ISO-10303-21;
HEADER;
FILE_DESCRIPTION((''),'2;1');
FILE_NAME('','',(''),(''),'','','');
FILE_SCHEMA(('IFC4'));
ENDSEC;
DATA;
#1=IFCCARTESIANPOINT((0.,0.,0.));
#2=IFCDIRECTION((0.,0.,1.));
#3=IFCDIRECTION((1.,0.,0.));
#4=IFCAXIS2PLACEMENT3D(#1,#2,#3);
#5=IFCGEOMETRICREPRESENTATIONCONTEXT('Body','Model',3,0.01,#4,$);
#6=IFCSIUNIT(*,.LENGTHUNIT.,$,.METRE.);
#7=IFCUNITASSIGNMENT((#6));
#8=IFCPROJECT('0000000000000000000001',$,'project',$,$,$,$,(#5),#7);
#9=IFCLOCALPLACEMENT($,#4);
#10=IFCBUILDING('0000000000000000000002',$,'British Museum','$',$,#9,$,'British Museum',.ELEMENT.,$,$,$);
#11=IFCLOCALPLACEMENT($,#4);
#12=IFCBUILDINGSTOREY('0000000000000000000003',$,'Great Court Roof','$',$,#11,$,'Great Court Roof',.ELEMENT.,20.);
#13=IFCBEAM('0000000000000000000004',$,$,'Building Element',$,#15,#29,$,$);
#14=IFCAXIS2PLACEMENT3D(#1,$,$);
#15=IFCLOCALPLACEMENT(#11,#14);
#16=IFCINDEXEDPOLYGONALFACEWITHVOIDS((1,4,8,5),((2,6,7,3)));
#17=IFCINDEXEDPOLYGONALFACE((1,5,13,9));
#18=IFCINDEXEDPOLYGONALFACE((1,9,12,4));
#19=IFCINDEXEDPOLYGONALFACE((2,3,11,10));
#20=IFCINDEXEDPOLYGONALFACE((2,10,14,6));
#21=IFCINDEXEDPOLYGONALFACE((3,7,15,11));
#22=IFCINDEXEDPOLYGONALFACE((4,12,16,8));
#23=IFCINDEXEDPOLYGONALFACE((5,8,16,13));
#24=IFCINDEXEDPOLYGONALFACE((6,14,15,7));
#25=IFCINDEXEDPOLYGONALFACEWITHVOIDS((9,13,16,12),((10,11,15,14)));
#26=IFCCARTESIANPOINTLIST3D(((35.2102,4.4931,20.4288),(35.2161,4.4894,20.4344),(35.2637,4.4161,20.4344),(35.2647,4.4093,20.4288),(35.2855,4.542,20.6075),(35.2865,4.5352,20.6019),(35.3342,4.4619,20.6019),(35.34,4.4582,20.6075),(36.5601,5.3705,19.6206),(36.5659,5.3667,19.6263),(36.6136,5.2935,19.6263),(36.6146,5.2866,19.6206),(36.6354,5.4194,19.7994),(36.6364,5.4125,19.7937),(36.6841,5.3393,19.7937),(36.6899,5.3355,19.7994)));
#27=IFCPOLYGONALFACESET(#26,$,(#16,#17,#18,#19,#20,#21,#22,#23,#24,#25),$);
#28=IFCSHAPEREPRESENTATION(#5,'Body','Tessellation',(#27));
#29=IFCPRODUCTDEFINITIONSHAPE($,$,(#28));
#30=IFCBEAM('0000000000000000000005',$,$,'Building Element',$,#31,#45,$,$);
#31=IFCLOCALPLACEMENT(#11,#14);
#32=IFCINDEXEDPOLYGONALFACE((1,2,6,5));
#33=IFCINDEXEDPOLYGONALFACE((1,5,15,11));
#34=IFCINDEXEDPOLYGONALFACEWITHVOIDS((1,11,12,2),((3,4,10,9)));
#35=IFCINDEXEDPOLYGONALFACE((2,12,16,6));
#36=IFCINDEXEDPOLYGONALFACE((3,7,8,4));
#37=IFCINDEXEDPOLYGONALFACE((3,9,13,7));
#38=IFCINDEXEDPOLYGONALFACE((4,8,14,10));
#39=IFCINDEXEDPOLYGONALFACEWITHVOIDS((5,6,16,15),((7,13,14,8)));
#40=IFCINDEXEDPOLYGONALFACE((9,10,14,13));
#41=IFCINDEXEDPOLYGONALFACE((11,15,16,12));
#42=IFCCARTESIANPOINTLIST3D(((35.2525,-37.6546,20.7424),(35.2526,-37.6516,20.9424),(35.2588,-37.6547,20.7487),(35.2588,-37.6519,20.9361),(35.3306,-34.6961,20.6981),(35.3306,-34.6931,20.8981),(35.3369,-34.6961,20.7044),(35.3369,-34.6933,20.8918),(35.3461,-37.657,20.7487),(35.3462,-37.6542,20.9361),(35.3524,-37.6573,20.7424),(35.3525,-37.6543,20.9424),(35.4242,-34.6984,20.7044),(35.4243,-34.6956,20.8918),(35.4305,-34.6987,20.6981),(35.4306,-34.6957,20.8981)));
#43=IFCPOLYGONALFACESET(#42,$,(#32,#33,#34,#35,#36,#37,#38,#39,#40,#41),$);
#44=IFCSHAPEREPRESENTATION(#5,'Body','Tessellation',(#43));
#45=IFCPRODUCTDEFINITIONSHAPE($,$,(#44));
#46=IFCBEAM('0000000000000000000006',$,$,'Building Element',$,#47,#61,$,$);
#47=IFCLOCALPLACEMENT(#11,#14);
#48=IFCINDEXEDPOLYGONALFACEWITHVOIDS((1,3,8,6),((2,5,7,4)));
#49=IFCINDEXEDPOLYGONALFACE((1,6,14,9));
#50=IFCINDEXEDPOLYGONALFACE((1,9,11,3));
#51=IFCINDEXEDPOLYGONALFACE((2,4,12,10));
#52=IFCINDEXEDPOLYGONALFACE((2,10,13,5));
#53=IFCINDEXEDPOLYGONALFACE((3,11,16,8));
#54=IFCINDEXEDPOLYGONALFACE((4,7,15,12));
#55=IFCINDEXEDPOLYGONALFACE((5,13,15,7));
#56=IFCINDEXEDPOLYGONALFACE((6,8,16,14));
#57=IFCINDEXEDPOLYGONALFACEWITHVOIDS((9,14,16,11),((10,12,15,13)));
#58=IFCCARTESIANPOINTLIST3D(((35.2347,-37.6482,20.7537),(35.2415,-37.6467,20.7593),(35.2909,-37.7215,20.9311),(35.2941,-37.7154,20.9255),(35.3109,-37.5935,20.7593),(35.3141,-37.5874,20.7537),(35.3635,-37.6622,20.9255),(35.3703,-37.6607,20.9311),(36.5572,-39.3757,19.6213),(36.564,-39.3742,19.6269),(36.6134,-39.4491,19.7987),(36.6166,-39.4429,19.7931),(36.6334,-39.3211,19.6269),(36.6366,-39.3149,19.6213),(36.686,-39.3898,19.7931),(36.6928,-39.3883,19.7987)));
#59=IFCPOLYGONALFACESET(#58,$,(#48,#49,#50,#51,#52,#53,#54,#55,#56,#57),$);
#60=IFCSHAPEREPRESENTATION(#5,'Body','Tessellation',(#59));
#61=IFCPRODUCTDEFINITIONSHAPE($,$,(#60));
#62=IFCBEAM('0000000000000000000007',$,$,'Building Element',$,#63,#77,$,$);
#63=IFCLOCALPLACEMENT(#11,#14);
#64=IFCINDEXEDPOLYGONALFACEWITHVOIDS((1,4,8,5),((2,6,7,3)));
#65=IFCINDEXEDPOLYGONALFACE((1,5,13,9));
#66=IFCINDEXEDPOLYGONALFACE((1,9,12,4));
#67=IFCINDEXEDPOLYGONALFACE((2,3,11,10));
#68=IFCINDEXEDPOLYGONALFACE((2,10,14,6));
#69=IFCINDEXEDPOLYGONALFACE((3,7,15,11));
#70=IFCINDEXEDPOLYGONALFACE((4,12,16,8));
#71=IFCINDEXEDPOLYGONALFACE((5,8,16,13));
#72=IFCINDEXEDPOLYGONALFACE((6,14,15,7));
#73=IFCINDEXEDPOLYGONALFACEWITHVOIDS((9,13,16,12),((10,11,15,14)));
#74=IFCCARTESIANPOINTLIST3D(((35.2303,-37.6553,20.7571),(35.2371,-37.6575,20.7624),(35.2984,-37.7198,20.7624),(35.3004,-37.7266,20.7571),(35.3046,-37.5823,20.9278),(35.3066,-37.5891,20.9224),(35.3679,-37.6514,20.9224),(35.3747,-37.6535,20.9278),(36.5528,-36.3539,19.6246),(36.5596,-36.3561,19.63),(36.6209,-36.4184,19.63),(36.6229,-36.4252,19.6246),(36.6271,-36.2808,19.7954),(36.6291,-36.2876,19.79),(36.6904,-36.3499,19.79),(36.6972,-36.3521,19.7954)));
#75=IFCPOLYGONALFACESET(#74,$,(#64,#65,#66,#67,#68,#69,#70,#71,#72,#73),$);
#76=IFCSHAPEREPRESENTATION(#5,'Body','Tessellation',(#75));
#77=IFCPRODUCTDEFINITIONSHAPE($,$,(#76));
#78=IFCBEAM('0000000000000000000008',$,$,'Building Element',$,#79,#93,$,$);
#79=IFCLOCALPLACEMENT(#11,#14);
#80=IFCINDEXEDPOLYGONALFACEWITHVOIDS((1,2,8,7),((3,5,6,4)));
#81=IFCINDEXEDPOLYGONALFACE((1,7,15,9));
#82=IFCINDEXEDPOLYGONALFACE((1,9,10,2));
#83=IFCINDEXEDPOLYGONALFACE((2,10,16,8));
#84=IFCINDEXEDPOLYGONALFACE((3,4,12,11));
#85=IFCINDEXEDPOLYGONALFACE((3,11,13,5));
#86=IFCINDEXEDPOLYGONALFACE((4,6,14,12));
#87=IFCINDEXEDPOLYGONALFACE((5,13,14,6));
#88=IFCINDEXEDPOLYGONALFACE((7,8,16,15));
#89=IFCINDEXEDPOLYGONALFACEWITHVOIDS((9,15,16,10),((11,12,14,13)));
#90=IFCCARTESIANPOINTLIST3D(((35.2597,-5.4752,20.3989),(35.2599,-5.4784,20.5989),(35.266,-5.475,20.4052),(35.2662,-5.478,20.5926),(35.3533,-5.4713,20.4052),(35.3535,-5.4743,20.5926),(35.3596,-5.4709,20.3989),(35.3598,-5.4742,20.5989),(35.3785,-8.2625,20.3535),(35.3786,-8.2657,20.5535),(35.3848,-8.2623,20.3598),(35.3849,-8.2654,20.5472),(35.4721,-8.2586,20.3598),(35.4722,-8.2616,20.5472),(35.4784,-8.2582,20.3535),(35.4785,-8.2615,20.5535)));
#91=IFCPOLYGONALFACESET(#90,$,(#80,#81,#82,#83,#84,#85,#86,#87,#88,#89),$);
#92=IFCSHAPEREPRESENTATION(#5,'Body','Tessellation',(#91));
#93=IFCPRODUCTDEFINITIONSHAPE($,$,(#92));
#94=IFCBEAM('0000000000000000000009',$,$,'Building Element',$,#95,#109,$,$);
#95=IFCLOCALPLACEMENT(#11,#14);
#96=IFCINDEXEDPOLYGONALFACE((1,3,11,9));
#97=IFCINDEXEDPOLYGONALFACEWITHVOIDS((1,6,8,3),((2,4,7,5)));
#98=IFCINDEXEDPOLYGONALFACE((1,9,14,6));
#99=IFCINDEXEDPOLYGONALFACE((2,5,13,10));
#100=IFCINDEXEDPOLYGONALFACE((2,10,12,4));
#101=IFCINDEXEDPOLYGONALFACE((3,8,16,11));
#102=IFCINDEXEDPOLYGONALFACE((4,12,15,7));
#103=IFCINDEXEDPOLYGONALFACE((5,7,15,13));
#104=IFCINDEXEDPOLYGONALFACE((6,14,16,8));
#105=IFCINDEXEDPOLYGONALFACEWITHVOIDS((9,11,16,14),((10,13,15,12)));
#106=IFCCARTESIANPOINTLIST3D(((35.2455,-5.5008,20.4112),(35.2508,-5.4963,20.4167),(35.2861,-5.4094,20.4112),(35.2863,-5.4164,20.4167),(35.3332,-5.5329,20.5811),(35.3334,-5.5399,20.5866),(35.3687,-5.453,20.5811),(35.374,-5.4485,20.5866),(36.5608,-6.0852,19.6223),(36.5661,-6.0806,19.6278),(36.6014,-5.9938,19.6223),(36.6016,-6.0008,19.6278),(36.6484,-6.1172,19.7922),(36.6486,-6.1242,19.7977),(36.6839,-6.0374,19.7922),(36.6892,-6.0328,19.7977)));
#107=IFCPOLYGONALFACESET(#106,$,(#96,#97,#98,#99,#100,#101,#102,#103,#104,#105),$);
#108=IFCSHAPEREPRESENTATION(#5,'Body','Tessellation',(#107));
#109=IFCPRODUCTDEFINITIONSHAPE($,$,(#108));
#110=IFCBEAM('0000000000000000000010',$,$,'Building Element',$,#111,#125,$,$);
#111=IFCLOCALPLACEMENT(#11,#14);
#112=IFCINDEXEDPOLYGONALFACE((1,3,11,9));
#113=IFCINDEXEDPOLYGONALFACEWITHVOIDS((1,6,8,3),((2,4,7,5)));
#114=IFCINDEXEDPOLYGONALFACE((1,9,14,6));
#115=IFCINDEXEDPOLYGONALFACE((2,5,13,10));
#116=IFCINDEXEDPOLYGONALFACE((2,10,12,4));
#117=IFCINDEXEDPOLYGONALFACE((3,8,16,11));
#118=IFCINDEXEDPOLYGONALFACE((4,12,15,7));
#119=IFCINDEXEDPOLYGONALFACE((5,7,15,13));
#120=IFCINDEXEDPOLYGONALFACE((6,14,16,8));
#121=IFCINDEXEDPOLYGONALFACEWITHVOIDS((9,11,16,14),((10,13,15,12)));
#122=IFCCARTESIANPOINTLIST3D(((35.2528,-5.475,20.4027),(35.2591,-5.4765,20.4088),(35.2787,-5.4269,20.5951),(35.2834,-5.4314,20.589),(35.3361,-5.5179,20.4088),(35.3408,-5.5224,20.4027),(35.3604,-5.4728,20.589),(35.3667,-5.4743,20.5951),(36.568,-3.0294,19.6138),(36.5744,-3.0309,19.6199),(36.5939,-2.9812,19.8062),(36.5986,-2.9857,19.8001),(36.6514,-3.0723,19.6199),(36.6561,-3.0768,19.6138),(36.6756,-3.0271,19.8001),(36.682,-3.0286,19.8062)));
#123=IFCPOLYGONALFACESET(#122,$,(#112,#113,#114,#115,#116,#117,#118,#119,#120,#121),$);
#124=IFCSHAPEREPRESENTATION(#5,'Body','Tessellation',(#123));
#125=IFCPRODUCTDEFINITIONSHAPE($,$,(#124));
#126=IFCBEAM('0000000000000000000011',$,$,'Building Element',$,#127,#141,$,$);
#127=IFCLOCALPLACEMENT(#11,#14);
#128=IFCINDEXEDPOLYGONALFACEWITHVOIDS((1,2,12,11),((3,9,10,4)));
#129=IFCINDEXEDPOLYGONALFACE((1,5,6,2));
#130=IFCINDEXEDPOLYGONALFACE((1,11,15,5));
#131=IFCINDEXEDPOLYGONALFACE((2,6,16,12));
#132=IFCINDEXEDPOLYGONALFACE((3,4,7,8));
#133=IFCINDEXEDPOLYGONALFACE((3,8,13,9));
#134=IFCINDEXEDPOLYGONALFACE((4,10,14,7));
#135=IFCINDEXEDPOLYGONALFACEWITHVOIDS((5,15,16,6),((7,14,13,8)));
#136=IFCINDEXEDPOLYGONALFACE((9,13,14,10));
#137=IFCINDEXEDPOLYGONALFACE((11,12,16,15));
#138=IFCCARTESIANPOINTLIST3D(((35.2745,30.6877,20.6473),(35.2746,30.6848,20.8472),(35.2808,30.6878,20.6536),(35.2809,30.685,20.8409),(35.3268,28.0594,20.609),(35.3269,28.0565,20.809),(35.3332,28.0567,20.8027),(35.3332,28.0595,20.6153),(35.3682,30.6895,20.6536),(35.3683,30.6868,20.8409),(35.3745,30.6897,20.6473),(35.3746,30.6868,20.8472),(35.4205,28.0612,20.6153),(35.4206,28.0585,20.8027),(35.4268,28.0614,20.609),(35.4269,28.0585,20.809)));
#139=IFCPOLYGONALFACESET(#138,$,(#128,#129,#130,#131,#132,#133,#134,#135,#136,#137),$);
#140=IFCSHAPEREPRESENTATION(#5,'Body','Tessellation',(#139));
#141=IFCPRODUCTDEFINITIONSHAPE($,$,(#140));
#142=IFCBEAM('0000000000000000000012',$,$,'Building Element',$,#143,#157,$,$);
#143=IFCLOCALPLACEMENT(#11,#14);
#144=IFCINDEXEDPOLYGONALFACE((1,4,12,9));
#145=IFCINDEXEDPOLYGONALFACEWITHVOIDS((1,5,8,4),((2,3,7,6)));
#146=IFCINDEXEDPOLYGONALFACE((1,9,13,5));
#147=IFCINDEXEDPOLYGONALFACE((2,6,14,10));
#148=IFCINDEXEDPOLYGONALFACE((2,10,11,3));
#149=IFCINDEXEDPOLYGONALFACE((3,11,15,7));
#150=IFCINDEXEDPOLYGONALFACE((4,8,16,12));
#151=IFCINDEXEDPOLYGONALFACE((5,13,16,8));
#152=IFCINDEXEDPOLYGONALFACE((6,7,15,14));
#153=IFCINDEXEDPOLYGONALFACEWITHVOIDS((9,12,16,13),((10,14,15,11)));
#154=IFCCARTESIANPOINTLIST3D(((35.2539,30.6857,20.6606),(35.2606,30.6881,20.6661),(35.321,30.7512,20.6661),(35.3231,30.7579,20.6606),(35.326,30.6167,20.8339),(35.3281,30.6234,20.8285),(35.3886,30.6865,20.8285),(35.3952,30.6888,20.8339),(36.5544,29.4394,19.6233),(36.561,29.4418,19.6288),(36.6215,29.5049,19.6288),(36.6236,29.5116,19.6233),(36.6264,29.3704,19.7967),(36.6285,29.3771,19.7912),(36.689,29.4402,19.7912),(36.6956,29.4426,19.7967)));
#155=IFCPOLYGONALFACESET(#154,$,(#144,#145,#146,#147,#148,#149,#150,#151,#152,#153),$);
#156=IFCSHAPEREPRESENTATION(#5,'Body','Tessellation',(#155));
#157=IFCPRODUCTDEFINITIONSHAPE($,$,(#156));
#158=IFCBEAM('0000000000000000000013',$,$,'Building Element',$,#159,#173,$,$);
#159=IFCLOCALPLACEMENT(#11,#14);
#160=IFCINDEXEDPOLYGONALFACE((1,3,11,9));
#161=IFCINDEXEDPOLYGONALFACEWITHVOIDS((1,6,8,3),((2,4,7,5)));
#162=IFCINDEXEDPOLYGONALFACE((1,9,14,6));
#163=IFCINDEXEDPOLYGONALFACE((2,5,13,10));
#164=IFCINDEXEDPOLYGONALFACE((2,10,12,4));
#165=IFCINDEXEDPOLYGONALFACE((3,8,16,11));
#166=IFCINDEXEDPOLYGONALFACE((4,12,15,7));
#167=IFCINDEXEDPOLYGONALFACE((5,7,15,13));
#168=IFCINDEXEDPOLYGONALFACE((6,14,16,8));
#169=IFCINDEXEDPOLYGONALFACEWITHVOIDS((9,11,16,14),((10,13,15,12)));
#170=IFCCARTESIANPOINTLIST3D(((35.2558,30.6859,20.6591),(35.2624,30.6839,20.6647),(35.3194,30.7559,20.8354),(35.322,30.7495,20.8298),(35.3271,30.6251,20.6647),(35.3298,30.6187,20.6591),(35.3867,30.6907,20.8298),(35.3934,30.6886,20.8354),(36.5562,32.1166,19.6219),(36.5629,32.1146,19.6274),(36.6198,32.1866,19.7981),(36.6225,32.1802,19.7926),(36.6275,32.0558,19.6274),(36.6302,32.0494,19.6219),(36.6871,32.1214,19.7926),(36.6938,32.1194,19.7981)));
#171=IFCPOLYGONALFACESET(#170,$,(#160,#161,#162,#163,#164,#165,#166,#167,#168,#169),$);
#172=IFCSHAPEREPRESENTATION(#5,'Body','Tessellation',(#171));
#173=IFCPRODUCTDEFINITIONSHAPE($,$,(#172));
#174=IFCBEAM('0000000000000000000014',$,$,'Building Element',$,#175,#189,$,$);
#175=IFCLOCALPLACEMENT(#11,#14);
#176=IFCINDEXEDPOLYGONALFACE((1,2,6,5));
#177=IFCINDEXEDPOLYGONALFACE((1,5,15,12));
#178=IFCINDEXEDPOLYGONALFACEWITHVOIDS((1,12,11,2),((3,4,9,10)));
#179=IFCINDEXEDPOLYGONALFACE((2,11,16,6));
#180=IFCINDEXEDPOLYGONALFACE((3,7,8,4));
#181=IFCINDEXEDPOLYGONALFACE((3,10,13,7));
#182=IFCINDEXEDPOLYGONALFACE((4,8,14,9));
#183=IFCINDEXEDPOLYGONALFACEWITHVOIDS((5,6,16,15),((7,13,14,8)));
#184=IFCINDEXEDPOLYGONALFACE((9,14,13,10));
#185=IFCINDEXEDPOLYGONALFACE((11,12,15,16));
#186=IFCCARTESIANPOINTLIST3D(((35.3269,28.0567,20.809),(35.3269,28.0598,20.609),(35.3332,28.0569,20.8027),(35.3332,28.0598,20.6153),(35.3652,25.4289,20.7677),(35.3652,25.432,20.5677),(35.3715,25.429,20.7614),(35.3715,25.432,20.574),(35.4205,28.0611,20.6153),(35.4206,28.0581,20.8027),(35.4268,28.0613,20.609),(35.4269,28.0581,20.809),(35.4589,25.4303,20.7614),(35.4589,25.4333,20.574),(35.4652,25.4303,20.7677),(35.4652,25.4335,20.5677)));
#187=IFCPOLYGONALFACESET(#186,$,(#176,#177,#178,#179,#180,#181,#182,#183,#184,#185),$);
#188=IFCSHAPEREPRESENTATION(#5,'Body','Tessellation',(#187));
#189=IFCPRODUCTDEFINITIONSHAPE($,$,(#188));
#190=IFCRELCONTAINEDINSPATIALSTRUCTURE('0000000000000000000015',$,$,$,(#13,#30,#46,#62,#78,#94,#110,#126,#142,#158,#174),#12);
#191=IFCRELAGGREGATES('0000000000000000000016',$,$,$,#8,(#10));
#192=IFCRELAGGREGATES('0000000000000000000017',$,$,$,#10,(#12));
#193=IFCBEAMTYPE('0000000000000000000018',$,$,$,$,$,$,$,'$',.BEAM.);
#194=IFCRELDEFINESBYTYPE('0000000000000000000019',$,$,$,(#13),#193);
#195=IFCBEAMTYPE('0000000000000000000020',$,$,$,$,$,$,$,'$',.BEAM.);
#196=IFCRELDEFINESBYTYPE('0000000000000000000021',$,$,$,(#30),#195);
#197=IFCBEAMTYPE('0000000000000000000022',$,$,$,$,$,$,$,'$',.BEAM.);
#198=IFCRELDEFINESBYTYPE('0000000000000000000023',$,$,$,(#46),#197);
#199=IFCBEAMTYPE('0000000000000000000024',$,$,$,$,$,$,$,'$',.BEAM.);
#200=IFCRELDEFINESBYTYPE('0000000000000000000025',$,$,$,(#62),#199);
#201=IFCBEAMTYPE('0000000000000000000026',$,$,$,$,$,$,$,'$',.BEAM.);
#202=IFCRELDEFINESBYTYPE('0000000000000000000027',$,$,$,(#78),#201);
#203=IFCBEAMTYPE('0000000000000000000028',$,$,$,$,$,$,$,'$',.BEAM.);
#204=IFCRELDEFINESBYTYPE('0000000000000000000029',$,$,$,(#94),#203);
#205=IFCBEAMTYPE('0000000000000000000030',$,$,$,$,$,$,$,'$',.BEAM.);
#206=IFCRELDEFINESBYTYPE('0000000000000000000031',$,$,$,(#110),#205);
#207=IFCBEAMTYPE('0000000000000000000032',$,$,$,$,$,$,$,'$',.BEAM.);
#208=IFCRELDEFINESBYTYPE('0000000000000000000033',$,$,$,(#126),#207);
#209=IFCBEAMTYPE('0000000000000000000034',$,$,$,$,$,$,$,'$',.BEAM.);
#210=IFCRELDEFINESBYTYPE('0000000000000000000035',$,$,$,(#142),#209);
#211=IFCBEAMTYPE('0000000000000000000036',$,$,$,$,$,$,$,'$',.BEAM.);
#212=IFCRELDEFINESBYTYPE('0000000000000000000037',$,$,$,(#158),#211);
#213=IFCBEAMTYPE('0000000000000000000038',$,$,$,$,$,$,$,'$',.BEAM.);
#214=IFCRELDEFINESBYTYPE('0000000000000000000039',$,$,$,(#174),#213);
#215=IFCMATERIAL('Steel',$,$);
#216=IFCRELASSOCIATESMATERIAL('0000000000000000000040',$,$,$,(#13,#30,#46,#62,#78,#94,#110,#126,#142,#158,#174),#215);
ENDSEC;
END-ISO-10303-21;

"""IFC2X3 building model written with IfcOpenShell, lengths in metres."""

from ifc_helpers import new_model, si_unit, frame, origin_with_axes, origin_2d, place, context, project, spatial, hollow_rectangle, extrude, material, type_object, element, save


model = new_model("IFC2X3")

# Units and contexts
model_context = context("Model", 3, precision=0.01, world=origin_with_axes(), identifier="Body")
ifc_project = project(units=[si_unit("LENGTHUNIT", "METRE")], contexts=[model_context])

# Building, storey
building_placement = place(None, origin_with_axes())
building = spatial("IfcBuilding", under=ifc_project, at=building_placement, Name="British Museum", Description="$", LongName="British Museum", CompositionType="ELEMENT")
storey_placement = place(None, origin_with_axes())
storey = spatial("IfcBuildingStorey", under=building, at=storey_placement, Name="Great Court Roof", Description="$", LongName="Great Court Roof", CompositionType="ELEMENT", Elevation=20.0)

# Beams
ifc_material = material(Name="Steel")
beam_type_1 = type_object("IfcBeamType", ElementType="$", PredefinedType="BEAM")
beam_1_placement = place(None, origin_with_axes())
element("IfcBeam", 1, at=beam_1_placement, inside=storey, type_object=beam_type_1, material=ifc_material, Description="Building Element", context=model_context, shape_type="SweptSolid", body=[
    extrude(hollow_rectangle(XDim=0.1, YDim=0.2, WallThickness=0.0063, InnerFilletRadius=-0.0063, OuterFilletRadius=0.0, at=origin_2d()), frame((35.2751, 4.4756, 20.5181), z_axis=(0.749354, 0.48705, -0.44861), x_axis=(-0.544965, 0.838459, 0.0)), (0.0, 0.0, 1.0), 1.8014),
])
beam_type_2 = type_object("IfcBeamType", ElementType="$", PredefinedType="BEAM")
beam_2_placement = place(None, origin_with_axes())
element("IfcBeam", 2, at=beam_2_placement, inside=storey, type_object=beam_type_2, material=ifc_material, Description="Building Element", context=model_context, shape_type="SweptSolid", body=[
    extrude(hollow_rectangle(XDim=0.1, YDim=0.2, WallThickness=0.0063, InnerFilletRadius=-0.0063, OuterFilletRadius=0.0, at=origin_2d()), frame((35.3025, -37.6544, 20.8424), z_axis=(0.026381, 0.99954, -0.014987), x_axis=(-0.999652, 0.026384, 0.0)), (0.0, 0.0, 1.0), 2.9599),
])
beam_type_3 = type_object("IfcBeamType", ElementType="$", PredefinedType="BEAM")
beam_3_placement = place(None, origin_with_axes())
element("IfcBeam", 3, at=beam_3_placement, inside=storey, type_object=beam_type_3, material=ifc_material, Description="Building Element", context=model_context, shape_type="SweptSolid", body=[
    extrude(hollow_rectangle(XDim=0.1, YDim=0.2, WallThickness=0.0063, InnerFilletRadius=-0.0063, OuterFilletRadius=0.0, at=origin_2d()), frame((35.3025, -37.6544, 20.8424), z_axis=(0.539199, -0.704341, -0.461701), x_axis=(0.794039, 0.607866, 0.0)), (0.0, 0.0, 1.0), 2.4527),
])
beam_type_4 = type_object("IfcBeamType", ElementType="$", PredefinedType="BEAM")
beam_4_placement = place(None, origin_with_axes())
element("IfcBeam", 4, at=beam_4_placement, inside=storey, type_object=beam_type_4, material=ifc_material, Description="Building Element", context=model_context, shape_type="SweptSolid", body=[
    extrude(hollow_rectangle(XDim=0.1, YDim=0.2, WallThickness=0.0063, InnerFilletRadius=-0.0063, OuterFilletRadius=0.0, at=origin_2d()), frame((35.3025, -37.6544, 20.8424), z_axis=(0.6084, 0.598711, -0.520956), x_axis=(-0.701409, 0.712759, 0.0)), (0.0, 0.0, 1.0), 2.1737),
])
beam_type_5 = type_object("IfcBeamType", ElementType="$", PredefinedType="BEAM")
beam_5_placement = place(None, origin_with_axes())
element("IfcBeam", 5, at=beam_5_placement, inside=storey, type_object=beam_type_5, material=ifc_material, Description="Building Element", context=model_context, shape_type="SweptSolid", body=[
    extrude(hollow_rectangle(XDim=0.1, YDim=0.2, WallThickness=0.0063, InnerFilletRadius=-0.0063, OuterFilletRadius=0.0, at=origin_2d()), frame((35.3098, -5.4747, 20.4989), z_axis=(0.042556, -0.998961, -0.016288), x_axis=(0.999094, 0.042562, 0.0)), (0.0, 0.0, 1.0), 2.7902),
])
beam_type_6 = type_object("IfcBeamType", ElementType="$", PredefinedType="BEAM")
beam_6_placement = place(None, origin_with_axes())
element("IfcBeam", 6, at=beam_6_placement, inside=storey, type_object=beam_type_6, material=ifc_material, Description="Building Element", context=model_context, shape_type="SweptSolid", body=[
    extrude(hollow_rectangle(XDim=0.1, YDim=0.2, WallThickness=0.0063, InnerFilletRadius=-0.0063, OuterFilletRadius=0.0, at=origin_2d()), frame((35.3098, -5.4747, 20.4989), z_axis=(0.801367, -0.356033, -0.480678), x_axis=(0.406015, 0.913867, 0.0)), (0.0, 0.0, 1.0), 1.6413),
])
beam_type_7 = type_object("IfcBeamType", ElementType="$", PredefinedType="BEAM")
beam_7_placement = place(None, origin_with_axes())
element("IfcBeam", 7, at=beam_7_placement, inside=storey, type_object=beam_type_7, material=ifc_material, Description="Building Element", context=model_context, shape_type="SweptSolid", body=[
    extrude(hollow_rectangle(XDim=0.1, YDim=0.2, WallThickness=0.0063, InnerFilletRadius=-0.0063, OuterFilletRadius=0.0, at=origin_2d()), frame((35.3098, -5.4747, 20.4989), z_axis=(0.455611, 0.847192, -0.273286), x_axis=(-0.880718, 0.473641, 0.0)), (0.0, 0.0, 1.0), 2.8868),
])
beam_type_8 = type_object("IfcBeamType", ElementType="$", PredefinedType="BEAM")
beam_8_placement = place(None, origin_with_axes())
element("IfcBeam", 8, at=beam_8_placement, inside=storey, type_object=beam_type_8, material=ifc_material, Description="Building Element", context=model_context, shape_type="SweptSolid", body=[
    extrude(hollow_rectangle(XDim=0.1, YDim=0.2, WallThickness=0.0063, InnerFilletRadius=-0.0063, OuterFilletRadius=0.0, at=origin_2d()), frame((35.3246, 30.6873, 20.7473), z_axis=(0.019898, -0.999696, -0.014537), x_axis=(0.999802, 0.0199, 0.0)), (0.0, 0.0, 1.0), 2.6291),
])
beam_type_9 = type_object("IfcBeamType", ElementType="$", PredefinedType="BEAM")
beam_9_placement = place(None, origin_with_axes())
element("IfcBeam", 9, at=beam_9_placement, inside=storey, type_object=beam_type_9, material=ifc_material, Description="Building Element", context=model_context, shape_type="SweptSolid", body=[
    extrude(hollow_rectangle(XDim=0.1, YDim=0.2, WallThickness=0.0063, InnerFilletRadius=-0.0063, OuterFilletRadius=0.0, at=origin_2d()), frame((35.3246, 30.6873, 20.7473), z_axis=(0.625658, -0.599598, -0.499033), x_axis=(0.691911, 0.721983, 0.0)), (0.0, 0.0, 1.0), 2.0785),
])
beam_type_10 = type_object("IfcBeamType", ElementType="$", PredefinedType="BEAM")
beam_10_placement = place(None, origin_with_axes())
element("IfcBeam", 10, at=beam_10_placement, inside=storey, type_object=beam_type_10, material=ifc_material, Description="Building Element", context=model_context, shape_type="SweptSolid", body=[
    extrude(hollow_rectangle(XDim=0.1, YDim=0.2, WallThickness=0.0063, InnerFilletRadius=-0.0063, OuterFilletRadius=0.0, at=origin_2d()), frame((35.3246, 30.6873, 20.7473), z_axis=(0.592705, 0.65208, -0.472749), x_axis=(-0.739994, 0.672613, 0.0)), (0.0, 0.0, 1.0), 2.1941),
])
beam_type_11 = type_object("IfcBeamType", ElementType="$", PredefinedType="BEAM")
beam_11_placement = place(None, origin_with_axes())
element("IfcBeam", 11, at=beam_11_placement, inside=storey, type_object=beam_type_11, material=ifc_material, Description="Building Element", context=model_context, shape_type="SweptSolid", body=[
    extrude(hollow_rectangle(XDim=0.1, YDim=0.2, WallThickness=0.0063, InnerFilletRadius=-0.0063, OuterFilletRadius=0.0, at=origin_2d()), frame((35.3769, 28.059, 20.709), z_axis=(0.014584, -0.99977, -0.015727), x_axis=(0.999894, 0.014586, 0.0)), (0.0, 0.0, 1.0), 2.6284),
])

save(model, "model.ifc")
